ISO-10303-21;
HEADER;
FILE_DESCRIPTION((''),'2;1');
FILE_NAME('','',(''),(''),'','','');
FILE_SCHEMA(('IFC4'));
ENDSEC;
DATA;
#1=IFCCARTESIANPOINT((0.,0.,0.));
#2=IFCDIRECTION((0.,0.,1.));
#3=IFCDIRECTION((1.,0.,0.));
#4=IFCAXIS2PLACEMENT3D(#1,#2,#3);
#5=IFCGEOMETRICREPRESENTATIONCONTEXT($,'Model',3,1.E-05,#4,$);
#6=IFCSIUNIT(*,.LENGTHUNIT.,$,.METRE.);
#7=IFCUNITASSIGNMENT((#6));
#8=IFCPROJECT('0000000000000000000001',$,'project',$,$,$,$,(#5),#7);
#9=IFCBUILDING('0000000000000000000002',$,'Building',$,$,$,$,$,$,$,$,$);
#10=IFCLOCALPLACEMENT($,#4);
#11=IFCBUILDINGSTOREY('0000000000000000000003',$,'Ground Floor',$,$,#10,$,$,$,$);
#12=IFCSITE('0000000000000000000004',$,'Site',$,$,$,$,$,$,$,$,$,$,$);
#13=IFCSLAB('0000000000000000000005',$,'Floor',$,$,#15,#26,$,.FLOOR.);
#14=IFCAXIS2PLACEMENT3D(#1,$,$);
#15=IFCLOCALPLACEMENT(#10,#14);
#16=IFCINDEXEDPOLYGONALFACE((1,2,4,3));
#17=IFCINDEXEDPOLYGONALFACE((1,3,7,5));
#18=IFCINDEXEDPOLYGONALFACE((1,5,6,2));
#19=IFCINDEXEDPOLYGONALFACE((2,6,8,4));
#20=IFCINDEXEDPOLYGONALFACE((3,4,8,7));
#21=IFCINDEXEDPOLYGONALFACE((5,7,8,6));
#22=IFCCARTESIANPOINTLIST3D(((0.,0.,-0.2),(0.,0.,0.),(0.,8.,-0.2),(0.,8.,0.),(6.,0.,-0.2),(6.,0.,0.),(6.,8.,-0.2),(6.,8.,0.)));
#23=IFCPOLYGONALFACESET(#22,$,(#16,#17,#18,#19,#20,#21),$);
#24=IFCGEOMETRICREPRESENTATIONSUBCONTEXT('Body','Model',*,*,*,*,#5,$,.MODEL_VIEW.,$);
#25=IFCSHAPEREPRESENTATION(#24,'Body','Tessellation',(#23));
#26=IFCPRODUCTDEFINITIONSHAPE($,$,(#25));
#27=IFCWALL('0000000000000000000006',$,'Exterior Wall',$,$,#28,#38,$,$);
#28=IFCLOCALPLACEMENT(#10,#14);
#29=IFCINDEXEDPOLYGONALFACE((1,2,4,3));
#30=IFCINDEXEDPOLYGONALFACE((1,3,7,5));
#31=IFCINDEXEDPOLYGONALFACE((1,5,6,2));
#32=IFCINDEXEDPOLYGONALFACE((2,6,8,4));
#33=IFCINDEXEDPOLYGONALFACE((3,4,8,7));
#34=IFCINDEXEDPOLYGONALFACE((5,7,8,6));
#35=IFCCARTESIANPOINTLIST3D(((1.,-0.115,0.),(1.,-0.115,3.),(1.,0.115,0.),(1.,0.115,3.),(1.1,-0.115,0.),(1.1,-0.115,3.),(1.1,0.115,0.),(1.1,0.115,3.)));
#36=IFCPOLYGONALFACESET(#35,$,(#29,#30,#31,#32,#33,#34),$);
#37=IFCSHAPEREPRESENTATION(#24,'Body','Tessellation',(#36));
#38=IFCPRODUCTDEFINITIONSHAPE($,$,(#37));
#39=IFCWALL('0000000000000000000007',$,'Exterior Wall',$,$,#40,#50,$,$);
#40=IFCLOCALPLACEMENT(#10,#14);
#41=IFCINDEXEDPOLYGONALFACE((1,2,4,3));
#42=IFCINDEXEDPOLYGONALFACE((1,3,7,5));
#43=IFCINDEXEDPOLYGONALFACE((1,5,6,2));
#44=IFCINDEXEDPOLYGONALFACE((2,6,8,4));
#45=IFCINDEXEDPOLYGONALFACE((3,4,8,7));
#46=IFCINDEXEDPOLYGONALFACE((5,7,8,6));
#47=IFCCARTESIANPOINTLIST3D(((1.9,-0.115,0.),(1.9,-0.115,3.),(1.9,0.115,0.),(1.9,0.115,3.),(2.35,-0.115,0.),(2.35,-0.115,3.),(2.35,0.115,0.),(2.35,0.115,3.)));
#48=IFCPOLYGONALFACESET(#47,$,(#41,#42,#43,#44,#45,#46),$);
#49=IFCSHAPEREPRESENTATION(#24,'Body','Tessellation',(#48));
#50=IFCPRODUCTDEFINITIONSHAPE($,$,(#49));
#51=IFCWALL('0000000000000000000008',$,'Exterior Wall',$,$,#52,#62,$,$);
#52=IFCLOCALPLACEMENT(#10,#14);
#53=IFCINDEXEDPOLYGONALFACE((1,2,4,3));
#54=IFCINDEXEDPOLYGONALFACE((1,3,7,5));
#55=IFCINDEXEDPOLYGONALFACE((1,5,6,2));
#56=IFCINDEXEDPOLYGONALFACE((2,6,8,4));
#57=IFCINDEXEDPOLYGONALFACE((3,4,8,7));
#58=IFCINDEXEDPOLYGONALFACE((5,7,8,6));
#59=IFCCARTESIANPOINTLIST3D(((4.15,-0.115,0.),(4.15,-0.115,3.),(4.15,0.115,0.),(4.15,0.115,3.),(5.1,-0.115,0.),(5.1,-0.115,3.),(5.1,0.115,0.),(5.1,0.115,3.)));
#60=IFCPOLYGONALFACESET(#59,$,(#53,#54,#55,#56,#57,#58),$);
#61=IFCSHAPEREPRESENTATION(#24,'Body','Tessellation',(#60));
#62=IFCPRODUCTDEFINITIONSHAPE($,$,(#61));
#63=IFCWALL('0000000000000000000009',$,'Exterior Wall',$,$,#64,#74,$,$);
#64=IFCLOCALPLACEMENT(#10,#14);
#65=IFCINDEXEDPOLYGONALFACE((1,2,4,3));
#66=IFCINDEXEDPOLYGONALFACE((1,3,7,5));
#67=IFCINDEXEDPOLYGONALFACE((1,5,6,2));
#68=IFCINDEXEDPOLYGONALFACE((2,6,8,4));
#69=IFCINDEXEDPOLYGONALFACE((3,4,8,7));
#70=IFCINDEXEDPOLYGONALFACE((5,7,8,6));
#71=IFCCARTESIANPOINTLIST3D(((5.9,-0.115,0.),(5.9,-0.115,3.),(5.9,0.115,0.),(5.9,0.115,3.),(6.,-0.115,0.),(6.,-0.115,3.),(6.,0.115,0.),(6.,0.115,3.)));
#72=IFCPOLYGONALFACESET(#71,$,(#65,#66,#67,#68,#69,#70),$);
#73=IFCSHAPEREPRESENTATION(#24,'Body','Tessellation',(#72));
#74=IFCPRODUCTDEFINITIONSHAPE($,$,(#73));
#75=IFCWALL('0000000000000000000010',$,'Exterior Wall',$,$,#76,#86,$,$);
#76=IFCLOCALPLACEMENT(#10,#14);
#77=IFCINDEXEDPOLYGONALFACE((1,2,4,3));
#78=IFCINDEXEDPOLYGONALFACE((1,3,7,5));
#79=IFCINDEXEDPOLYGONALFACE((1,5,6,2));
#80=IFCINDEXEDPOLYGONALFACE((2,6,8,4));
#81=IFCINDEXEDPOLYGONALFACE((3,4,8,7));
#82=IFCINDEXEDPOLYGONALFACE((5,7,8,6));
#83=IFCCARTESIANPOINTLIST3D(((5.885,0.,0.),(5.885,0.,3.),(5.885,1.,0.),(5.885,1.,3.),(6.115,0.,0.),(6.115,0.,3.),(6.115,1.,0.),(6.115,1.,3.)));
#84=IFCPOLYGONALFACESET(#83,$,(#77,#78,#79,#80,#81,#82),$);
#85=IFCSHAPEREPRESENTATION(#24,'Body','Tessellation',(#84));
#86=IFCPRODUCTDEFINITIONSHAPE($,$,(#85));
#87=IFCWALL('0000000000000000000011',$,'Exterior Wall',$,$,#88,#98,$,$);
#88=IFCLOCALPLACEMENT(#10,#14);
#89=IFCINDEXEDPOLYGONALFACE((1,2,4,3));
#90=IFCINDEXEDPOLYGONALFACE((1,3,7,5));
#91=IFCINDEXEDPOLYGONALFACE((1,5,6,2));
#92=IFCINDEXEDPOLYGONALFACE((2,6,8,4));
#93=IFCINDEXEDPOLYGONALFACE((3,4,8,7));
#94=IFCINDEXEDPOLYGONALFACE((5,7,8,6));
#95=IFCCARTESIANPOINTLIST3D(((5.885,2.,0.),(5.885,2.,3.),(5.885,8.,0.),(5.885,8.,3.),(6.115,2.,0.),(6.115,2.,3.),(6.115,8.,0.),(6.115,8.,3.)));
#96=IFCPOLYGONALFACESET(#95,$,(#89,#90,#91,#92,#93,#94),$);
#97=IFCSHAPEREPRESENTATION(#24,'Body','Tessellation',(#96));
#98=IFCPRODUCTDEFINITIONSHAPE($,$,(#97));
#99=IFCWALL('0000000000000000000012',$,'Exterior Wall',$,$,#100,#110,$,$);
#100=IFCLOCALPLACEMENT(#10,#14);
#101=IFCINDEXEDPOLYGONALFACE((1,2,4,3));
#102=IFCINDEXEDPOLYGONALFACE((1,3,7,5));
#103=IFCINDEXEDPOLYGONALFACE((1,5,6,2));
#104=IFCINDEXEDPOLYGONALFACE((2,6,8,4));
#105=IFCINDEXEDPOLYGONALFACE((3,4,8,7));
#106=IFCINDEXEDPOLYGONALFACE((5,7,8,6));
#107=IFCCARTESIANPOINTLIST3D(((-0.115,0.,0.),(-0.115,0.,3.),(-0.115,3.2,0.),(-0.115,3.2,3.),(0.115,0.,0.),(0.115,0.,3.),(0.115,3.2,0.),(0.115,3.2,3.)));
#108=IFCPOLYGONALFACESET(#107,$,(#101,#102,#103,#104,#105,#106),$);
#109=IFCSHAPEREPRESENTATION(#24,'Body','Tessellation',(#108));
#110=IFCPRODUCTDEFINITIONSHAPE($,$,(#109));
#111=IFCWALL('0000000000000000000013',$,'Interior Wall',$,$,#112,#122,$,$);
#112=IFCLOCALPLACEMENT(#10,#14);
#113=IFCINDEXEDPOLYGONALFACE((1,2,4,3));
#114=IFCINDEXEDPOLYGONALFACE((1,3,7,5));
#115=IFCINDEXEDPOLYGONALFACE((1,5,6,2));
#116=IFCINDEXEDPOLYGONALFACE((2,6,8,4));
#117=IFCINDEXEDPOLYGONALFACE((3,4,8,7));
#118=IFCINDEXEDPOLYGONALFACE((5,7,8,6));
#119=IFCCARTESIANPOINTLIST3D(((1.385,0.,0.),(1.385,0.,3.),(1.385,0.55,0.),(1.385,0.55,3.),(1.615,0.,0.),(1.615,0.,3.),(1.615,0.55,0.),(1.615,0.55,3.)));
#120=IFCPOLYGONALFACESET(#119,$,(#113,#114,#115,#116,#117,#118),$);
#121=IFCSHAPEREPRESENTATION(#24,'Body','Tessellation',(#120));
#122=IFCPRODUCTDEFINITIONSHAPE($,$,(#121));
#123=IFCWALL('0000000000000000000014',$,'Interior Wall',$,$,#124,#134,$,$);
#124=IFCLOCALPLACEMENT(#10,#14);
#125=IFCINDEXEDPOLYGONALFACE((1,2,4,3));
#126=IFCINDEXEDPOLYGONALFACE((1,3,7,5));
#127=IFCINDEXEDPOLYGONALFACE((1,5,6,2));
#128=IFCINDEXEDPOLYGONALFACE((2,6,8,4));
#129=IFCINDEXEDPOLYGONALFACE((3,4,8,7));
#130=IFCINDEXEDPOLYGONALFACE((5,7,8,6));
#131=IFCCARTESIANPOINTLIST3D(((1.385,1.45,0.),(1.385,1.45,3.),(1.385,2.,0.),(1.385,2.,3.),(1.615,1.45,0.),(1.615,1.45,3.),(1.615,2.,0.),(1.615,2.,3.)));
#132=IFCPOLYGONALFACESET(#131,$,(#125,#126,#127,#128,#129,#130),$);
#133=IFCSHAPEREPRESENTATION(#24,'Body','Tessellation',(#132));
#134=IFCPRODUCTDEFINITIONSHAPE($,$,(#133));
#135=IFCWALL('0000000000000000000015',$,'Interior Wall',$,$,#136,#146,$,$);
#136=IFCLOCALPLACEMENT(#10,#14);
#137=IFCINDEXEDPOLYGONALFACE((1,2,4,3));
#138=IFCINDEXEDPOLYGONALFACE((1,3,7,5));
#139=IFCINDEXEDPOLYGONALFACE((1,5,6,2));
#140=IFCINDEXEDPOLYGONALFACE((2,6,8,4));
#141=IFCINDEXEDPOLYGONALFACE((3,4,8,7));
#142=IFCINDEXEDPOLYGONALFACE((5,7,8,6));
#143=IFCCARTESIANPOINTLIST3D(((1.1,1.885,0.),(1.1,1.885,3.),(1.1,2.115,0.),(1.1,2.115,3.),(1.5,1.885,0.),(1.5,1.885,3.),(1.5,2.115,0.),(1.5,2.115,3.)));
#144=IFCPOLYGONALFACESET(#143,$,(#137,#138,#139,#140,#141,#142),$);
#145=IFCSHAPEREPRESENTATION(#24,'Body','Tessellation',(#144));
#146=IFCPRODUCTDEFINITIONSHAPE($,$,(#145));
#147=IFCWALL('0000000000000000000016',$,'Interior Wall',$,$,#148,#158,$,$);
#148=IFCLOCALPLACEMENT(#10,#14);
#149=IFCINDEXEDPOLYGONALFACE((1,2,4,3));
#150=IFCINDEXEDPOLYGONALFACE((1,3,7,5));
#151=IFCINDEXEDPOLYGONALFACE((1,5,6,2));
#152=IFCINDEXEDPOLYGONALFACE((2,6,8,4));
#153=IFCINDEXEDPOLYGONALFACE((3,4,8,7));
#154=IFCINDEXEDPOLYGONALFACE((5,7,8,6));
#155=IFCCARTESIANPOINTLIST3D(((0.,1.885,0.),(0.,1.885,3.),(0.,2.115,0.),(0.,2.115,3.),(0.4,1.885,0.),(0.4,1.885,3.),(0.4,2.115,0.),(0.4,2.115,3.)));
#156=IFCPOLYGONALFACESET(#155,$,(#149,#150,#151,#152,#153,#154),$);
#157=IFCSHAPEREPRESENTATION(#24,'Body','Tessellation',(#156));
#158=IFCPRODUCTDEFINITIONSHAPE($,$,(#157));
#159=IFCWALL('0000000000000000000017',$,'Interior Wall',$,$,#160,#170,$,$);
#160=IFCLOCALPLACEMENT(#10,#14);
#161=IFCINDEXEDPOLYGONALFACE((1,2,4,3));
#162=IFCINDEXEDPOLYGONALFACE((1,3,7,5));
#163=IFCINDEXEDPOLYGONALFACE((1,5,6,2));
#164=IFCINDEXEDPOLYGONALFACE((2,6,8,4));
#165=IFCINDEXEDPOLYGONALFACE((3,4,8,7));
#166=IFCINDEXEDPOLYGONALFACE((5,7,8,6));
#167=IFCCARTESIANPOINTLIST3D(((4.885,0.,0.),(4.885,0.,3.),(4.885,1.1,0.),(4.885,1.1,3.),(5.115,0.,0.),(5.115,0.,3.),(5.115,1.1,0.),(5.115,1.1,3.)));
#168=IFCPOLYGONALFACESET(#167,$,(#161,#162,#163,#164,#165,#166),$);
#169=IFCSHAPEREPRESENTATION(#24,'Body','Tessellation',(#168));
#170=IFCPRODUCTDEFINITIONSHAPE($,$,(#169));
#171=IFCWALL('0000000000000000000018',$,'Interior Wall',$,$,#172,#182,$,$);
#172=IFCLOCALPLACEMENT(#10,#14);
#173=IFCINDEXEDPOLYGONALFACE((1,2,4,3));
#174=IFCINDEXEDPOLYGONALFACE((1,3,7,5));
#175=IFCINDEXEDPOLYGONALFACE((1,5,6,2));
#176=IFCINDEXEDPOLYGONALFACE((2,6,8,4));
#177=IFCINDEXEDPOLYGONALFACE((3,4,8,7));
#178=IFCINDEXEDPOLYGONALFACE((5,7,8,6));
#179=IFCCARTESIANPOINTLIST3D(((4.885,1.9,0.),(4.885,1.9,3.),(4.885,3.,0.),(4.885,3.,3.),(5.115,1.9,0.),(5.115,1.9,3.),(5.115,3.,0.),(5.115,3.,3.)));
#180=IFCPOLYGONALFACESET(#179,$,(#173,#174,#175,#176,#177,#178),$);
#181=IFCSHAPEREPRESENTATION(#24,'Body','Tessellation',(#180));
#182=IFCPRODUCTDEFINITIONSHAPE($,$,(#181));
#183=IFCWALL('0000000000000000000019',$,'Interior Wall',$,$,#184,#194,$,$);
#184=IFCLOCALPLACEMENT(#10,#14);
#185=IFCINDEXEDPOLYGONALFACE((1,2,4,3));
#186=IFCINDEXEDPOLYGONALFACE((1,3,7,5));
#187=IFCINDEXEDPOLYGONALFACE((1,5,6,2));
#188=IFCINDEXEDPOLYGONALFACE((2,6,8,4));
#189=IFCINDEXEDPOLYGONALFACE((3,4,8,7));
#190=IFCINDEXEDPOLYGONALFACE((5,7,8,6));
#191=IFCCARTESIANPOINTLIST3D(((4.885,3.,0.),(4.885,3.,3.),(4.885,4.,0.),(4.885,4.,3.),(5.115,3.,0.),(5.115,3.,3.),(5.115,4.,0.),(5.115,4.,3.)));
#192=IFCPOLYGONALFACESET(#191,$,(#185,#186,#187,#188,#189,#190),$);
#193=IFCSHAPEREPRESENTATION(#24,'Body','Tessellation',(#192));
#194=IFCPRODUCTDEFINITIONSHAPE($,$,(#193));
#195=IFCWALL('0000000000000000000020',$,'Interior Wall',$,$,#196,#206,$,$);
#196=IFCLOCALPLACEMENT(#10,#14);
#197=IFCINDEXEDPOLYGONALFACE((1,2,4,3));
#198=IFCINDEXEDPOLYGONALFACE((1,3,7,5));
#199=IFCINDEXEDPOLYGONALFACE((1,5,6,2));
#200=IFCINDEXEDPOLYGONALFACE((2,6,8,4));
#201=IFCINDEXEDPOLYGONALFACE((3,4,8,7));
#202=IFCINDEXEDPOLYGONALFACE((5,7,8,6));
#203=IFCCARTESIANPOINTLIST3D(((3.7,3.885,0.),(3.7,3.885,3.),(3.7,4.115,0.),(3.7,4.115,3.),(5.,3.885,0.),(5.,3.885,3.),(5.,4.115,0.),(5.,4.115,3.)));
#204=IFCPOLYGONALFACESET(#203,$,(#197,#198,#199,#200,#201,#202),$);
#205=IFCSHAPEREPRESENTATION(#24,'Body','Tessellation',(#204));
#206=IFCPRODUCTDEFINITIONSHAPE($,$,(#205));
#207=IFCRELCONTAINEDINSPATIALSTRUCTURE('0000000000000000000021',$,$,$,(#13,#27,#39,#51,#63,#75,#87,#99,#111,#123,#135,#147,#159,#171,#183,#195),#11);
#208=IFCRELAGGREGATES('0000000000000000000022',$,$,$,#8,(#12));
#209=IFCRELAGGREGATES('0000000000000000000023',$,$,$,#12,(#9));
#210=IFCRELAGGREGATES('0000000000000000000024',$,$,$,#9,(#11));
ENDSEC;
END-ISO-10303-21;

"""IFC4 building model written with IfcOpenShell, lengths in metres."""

from ifc_helpers import new_model, si_unit, frame, origin_with_axes, place, context, subcontext, project, spatial, indexed_curve, outline, extrude, element, save


model = new_model("IFC4")

# Units and contexts
model_context = context("Model", 3, precision=1e-05, world=origin_with_axes())
body_context = subcontext(model_context, "Body", "Model", "MODEL_VIEW")
ifc_project = project(units=[si_unit("LENGTHUNIT", "METRE")], contexts=[model_context])

# Site, building, storey
site = spatial("IfcSite", under=ifc_project, Name="Site")
building = spatial("IfcBuilding", under=site, Name="Building")
storey_placement = place(None, origin_with_axes())
storey = spatial("IfcBuildingStorey", under=building, at=storey_placement, Name="Ground Floor")

# Slab
slab_placement = place(storey_placement, frame((0.0, 0.0, -0.2), z_axis=(0.0, 0.0, 1.0), x_axis=(1.0, 0.0, 0.0)))
element("IfcSlab", 1, at=slab_placement, inside=storey, Name="Floor", PredefinedType="FLOOR", context=body_context, shape_type="SweptSolid", body=[
    extrude(outline(indexed_curve([(0.0, 0.0), (6.0, 0.0), (6.0, 8.0), (0.0, 8.0)])), None, (0.0, 0.0, 1.0), 0.2),
])

# Walls
wall_1_placement = place(storey_placement, frame((1.0, 0.0, 0.0), z_axis=(0.0, 0.0, 1.0), x_axis=(1.0, 0.0, 0.0)))
element("IfcWall", 2, at=wall_1_placement, inside=storey, Name="Exterior Wall", context=body_context, shape_type="SweptSolid", body=[
    extrude(outline(indexed_curve([(0.0, 0.0), (0.0, 0.23), (0.1, 0.23), (0.1, 0.0), (0.0, 0.0)], self_intersect=False)), frame((0.0, -0.115, 0.0), z_axis=(0.0, 0.0, 1.0), x_axis=(1.0, 0.0, 0.0)), (0.0, 0.0, 1.0), 3.0),
])
wall_2_placement = place(storey_placement, frame((1.9, 0.0, 0.0), z_axis=(0.0, 0.0, 1.0), x_axis=(1.0, 0.0, 0.0)))
element("IfcWall", 3, at=wall_2_placement, inside=storey, Name="Exterior Wall", context=body_context, shape_type="SweptSolid", body=[
    extrude(outline(indexed_curve([(0.0, 0.0), (0.0, 0.23), (0.45, 0.23), (0.45, 0.0), (0.0, 0.0)], self_intersect=False)), frame((0.0, -0.115, 0.0), z_axis=(0.0, 0.0, 1.0), x_axis=(1.0, 0.0, 0.0)), (0.0, 0.0, 1.0), 3.0),
])
wall_3_placement = place(storey_placement, frame((4.15, 0.0, 0.0), z_axis=(0.0, 0.0, 1.0), x_axis=(1.0, 0.0, 0.0)))
element("IfcWall", 4, at=wall_3_placement, inside=storey, Name="Exterior Wall", context=body_context, shape_type="SweptSolid", body=[
    extrude(outline(indexed_curve([(0.0, 0.0), (0.0, 0.23), (0.95, 0.23), (0.95, 0.0), (0.0, 0.0)], self_intersect=False)), frame((0.0, -0.115, 0.0), z_axis=(0.0, 0.0, 1.0), x_axis=(1.0, 0.0, 0.0)), (0.0, 0.0, 1.0), 3.0),
])
wall_4_placement = place(storey_placement, frame((5.9, 0.0, 0.0), z_axis=(0.0, 0.0, 1.0), x_axis=(1.0, 0.0, 0.0)))
element("IfcWall", 5, at=wall_4_placement, inside=storey, Name="Exterior Wall", context=body_context, shape_type="SweptSolid", body=[
    extrude(outline(indexed_curve([(0.0, 0.0), (0.0, 0.23), (0.1, 0.23), (0.1, 0.0), (0.0, 0.0)], self_intersect=False)), frame((0.0, -0.115, 0.0), z_axis=(0.0, 0.0, 1.0), x_axis=(1.0, 0.0, 0.0)), (0.0, 0.0, 1.0), 3.0),
])
wall_5_placement = place(storey_placement, frame((6.0, 0.0, 0.0), z_axis=(0.0, 0.0, 1.0), x_axis=(0.0, 1.0, 0.0)))
element("IfcWall", 6, at=wall_5_placement, inside=storey, Name="Exterior Wall", context=body_context, shape_type="SweptSolid", body=[
    extrude(outline(indexed_curve([(0.0, 0.0), (0.0, 0.23), (1.0, 0.23), (1.0, 0.0), (0.0, 0.0)], self_intersect=False)), frame((0.0, -0.115, 0.0), z_axis=(0.0, 0.0, 1.0), x_axis=(1.0, 0.0, 0.0)), (0.0, 0.0, 1.0), 3.0),
])
wall_6_placement = place(storey_placement, frame((6.0, 2.0, 0.0), z_axis=(0.0, 0.0, 1.0), x_axis=(0.0, 1.0, 0.0)))
element("IfcWall", 7, at=wall_6_placement, inside=storey, Name="Exterior Wall", context=body_context, shape_type="SweptSolid", body=[
    extrude(outline(indexed_curve([(0.0, 0.0), (0.0, 0.23), (6.0, 0.23), (6.0, 0.0), (0.0, 0.0)], self_intersect=False)), frame((0.0, -0.115, 0.0), z_axis=(0.0, 0.0, 1.0), x_axis=(1.0, 0.0, 0.0)), (0.0, 0.0, 1.0), 3.0),
])
wall_7_placement = place(storey_placement, frame((0.0, 3.2, 0.0), z_axis=(0.0, 0.0, 1.0), x_axis=(0.0, -1.0, 0.0)))
element("IfcWall", 8, at=wall_7_placement, inside=storey, Name="Exterior Wall", context=body_context, shape_type="SweptSolid", body=[
    extrude(outline(indexed_curve([(0.0, 0.0), (0.0, 0.23), (3.2, 0.23), (3.2, 0.0), (0.0, 0.0)], self_intersect=False)), frame((0.0, -0.115, 0.0), z_axis=(0.0, 0.0, 1.0), x_axis=(1.0, 0.0, 0.0)), (0.0, 0.0, 1.0), 3.0),
])
for number, where, z_axis, x_axis, name in (
    (9, (1.5, 0.0, 0.0), (0.0, 0.0, 1.0), (0.0, 1.0, 0.0), "Interior Wall"),
    (10, (1.5, 1.45, 0.0), (0.0, 0.0, 1.0), (0.0, 1.0, 0.0), "Interior Wall"),
):
    element("IfcWall", number, at=place(storey_placement, frame(where, z_axis=z_axis, x_axis=x_axis)), inside=storey, Name=name, context=body_context, shape_type="SweptSolid", body=[
        extrude(outline(indexed_curve([(0.0, 0.0), (0.0, 0.23), (0.55, 0.23), (0.55, 0.0), (0.0, 0.0)], self_intersect=False)), frame((0.0, -0.115, 0.0), z_axis=(0.0, 0.0, 1.0), x_axis=(1.0, 0.0, 0.0)), (0.0, 0.0, 1.0), 3.0),
    ])
for number, where, z_axis, x_axis, name in (
    (11, (1.5, 2.0, 0.0), (0.0, 0.0, 1.0), (-1.0, 0.0, 0.0), "Interior Wall"),
    (12, (0.4, 2.0, 0.0), (0.0, 0.0, 1.0), (-1.0, 0.0, 0.0), "Interior Wall"),
):
    element("IfcWall", number, at=place(storey_placement, frame(where, z_axis=z_axis, x_axis=x_axis)), inside=storey, Name=name, context=body_context, shape_type="SweptSolid", body=[
        extrude(outline(indexed_curve([(0.0, 0.0), (0.0, 0.23), (0.4, 0.23), (0.4, 0.0), (0.0, 0.0)], self_intersect=False)), frame((0.0, -0.115, 0.0), z_axis=(0.0, 0.0, 1.0), x_axis=(1.0, 0.0, 0.0)), (0.0, 0.0, 1.0), 3.0),
    ])
for number, where, z_axis, x_axis, name in (
    (13, (5.0, 0.0, 0.0), (0.0, 0.0, 1.0), (0.0, 1.0, 0.0), "Interior Wall"),
    (14, (5.0, 1.9, 0.0), (0.0, 0.0, 1.0), (0.0, 1.0, 0.0), "Interior Wall"),
):
    element("IfcWall", number, at=place(storey_placement, frame(where, z_axis=z_axis, x_axis=x_axis)), inside=storey, Name=name, context=body_context, shape_type="SweptSolid", body=[
        extrude(outline(indexed_curve([(0.0, 0.0), (0.0, 0.23), (1.1, 0.23), (1.1, 0.0), (0.0, 0.0)], self_intersect=False)), frame((0.0, -0.115, 0.0), z_axis=(0.0, 0.0, 1.0), x_axis=(1.0, 0.0, 0.0)), (0.0, 0.0, 1.0), 3.0),
    ])
wall_8_placement = place(storey_placement, frame((5.0, 3.0, 0.0), z_axis=(0.0, 0.0, 1.0), x_axis=(0.0, 1.0, 0.0)))
element("IfcWall", 15, at=wall_8_placement, inside=storey, Name="Interior Wall", context=body_context, shape_type="SweptSolid", body=[
    extrude(outline(indexed_curve([(0.0, 0.0), (0.0, 0.23), (1.0, 0.23), (1.0, 0.0), (0.0, 0.0)], self_intersect=False)), frame((0.0, -0.115, 0.0), z_axis=(0.0, 0.0, 1.0), x_axis=(1.0, 0.0, 0.0)), (0.0, 0.0, 1.0), 3.0),
])
for number, where, z_axis, x_axis, name in (
    (16, (5.0, 4.0, 0.0), (0.0, 0.0, 1.0), (-1.0, 0.0, 0.0), "Interior Wall"),
):
    element("IfcWall", number, at=place(storey_placement, frame(where, z_axis=z_axis, x_axis=x_axis)), inside=storey, Name=name, context=body_context, shape_type="SweptSolid", body=[
        extrude(outline(indexed_curve([(0.0, 0.0), (0.0, 0.23), (1.3, 0.23), (1.3, 0.0), (0.0, 0.0)], self_intersect=False)), frame((0.0, -0.115, 0.0), z_axis=(0.0, 0.0, 1.0), x_axis=(1.0, 0.0, 0.0)), (0.0, 0.0, 1.0), 3.0),
    ])

save(model, "model.ifc")
